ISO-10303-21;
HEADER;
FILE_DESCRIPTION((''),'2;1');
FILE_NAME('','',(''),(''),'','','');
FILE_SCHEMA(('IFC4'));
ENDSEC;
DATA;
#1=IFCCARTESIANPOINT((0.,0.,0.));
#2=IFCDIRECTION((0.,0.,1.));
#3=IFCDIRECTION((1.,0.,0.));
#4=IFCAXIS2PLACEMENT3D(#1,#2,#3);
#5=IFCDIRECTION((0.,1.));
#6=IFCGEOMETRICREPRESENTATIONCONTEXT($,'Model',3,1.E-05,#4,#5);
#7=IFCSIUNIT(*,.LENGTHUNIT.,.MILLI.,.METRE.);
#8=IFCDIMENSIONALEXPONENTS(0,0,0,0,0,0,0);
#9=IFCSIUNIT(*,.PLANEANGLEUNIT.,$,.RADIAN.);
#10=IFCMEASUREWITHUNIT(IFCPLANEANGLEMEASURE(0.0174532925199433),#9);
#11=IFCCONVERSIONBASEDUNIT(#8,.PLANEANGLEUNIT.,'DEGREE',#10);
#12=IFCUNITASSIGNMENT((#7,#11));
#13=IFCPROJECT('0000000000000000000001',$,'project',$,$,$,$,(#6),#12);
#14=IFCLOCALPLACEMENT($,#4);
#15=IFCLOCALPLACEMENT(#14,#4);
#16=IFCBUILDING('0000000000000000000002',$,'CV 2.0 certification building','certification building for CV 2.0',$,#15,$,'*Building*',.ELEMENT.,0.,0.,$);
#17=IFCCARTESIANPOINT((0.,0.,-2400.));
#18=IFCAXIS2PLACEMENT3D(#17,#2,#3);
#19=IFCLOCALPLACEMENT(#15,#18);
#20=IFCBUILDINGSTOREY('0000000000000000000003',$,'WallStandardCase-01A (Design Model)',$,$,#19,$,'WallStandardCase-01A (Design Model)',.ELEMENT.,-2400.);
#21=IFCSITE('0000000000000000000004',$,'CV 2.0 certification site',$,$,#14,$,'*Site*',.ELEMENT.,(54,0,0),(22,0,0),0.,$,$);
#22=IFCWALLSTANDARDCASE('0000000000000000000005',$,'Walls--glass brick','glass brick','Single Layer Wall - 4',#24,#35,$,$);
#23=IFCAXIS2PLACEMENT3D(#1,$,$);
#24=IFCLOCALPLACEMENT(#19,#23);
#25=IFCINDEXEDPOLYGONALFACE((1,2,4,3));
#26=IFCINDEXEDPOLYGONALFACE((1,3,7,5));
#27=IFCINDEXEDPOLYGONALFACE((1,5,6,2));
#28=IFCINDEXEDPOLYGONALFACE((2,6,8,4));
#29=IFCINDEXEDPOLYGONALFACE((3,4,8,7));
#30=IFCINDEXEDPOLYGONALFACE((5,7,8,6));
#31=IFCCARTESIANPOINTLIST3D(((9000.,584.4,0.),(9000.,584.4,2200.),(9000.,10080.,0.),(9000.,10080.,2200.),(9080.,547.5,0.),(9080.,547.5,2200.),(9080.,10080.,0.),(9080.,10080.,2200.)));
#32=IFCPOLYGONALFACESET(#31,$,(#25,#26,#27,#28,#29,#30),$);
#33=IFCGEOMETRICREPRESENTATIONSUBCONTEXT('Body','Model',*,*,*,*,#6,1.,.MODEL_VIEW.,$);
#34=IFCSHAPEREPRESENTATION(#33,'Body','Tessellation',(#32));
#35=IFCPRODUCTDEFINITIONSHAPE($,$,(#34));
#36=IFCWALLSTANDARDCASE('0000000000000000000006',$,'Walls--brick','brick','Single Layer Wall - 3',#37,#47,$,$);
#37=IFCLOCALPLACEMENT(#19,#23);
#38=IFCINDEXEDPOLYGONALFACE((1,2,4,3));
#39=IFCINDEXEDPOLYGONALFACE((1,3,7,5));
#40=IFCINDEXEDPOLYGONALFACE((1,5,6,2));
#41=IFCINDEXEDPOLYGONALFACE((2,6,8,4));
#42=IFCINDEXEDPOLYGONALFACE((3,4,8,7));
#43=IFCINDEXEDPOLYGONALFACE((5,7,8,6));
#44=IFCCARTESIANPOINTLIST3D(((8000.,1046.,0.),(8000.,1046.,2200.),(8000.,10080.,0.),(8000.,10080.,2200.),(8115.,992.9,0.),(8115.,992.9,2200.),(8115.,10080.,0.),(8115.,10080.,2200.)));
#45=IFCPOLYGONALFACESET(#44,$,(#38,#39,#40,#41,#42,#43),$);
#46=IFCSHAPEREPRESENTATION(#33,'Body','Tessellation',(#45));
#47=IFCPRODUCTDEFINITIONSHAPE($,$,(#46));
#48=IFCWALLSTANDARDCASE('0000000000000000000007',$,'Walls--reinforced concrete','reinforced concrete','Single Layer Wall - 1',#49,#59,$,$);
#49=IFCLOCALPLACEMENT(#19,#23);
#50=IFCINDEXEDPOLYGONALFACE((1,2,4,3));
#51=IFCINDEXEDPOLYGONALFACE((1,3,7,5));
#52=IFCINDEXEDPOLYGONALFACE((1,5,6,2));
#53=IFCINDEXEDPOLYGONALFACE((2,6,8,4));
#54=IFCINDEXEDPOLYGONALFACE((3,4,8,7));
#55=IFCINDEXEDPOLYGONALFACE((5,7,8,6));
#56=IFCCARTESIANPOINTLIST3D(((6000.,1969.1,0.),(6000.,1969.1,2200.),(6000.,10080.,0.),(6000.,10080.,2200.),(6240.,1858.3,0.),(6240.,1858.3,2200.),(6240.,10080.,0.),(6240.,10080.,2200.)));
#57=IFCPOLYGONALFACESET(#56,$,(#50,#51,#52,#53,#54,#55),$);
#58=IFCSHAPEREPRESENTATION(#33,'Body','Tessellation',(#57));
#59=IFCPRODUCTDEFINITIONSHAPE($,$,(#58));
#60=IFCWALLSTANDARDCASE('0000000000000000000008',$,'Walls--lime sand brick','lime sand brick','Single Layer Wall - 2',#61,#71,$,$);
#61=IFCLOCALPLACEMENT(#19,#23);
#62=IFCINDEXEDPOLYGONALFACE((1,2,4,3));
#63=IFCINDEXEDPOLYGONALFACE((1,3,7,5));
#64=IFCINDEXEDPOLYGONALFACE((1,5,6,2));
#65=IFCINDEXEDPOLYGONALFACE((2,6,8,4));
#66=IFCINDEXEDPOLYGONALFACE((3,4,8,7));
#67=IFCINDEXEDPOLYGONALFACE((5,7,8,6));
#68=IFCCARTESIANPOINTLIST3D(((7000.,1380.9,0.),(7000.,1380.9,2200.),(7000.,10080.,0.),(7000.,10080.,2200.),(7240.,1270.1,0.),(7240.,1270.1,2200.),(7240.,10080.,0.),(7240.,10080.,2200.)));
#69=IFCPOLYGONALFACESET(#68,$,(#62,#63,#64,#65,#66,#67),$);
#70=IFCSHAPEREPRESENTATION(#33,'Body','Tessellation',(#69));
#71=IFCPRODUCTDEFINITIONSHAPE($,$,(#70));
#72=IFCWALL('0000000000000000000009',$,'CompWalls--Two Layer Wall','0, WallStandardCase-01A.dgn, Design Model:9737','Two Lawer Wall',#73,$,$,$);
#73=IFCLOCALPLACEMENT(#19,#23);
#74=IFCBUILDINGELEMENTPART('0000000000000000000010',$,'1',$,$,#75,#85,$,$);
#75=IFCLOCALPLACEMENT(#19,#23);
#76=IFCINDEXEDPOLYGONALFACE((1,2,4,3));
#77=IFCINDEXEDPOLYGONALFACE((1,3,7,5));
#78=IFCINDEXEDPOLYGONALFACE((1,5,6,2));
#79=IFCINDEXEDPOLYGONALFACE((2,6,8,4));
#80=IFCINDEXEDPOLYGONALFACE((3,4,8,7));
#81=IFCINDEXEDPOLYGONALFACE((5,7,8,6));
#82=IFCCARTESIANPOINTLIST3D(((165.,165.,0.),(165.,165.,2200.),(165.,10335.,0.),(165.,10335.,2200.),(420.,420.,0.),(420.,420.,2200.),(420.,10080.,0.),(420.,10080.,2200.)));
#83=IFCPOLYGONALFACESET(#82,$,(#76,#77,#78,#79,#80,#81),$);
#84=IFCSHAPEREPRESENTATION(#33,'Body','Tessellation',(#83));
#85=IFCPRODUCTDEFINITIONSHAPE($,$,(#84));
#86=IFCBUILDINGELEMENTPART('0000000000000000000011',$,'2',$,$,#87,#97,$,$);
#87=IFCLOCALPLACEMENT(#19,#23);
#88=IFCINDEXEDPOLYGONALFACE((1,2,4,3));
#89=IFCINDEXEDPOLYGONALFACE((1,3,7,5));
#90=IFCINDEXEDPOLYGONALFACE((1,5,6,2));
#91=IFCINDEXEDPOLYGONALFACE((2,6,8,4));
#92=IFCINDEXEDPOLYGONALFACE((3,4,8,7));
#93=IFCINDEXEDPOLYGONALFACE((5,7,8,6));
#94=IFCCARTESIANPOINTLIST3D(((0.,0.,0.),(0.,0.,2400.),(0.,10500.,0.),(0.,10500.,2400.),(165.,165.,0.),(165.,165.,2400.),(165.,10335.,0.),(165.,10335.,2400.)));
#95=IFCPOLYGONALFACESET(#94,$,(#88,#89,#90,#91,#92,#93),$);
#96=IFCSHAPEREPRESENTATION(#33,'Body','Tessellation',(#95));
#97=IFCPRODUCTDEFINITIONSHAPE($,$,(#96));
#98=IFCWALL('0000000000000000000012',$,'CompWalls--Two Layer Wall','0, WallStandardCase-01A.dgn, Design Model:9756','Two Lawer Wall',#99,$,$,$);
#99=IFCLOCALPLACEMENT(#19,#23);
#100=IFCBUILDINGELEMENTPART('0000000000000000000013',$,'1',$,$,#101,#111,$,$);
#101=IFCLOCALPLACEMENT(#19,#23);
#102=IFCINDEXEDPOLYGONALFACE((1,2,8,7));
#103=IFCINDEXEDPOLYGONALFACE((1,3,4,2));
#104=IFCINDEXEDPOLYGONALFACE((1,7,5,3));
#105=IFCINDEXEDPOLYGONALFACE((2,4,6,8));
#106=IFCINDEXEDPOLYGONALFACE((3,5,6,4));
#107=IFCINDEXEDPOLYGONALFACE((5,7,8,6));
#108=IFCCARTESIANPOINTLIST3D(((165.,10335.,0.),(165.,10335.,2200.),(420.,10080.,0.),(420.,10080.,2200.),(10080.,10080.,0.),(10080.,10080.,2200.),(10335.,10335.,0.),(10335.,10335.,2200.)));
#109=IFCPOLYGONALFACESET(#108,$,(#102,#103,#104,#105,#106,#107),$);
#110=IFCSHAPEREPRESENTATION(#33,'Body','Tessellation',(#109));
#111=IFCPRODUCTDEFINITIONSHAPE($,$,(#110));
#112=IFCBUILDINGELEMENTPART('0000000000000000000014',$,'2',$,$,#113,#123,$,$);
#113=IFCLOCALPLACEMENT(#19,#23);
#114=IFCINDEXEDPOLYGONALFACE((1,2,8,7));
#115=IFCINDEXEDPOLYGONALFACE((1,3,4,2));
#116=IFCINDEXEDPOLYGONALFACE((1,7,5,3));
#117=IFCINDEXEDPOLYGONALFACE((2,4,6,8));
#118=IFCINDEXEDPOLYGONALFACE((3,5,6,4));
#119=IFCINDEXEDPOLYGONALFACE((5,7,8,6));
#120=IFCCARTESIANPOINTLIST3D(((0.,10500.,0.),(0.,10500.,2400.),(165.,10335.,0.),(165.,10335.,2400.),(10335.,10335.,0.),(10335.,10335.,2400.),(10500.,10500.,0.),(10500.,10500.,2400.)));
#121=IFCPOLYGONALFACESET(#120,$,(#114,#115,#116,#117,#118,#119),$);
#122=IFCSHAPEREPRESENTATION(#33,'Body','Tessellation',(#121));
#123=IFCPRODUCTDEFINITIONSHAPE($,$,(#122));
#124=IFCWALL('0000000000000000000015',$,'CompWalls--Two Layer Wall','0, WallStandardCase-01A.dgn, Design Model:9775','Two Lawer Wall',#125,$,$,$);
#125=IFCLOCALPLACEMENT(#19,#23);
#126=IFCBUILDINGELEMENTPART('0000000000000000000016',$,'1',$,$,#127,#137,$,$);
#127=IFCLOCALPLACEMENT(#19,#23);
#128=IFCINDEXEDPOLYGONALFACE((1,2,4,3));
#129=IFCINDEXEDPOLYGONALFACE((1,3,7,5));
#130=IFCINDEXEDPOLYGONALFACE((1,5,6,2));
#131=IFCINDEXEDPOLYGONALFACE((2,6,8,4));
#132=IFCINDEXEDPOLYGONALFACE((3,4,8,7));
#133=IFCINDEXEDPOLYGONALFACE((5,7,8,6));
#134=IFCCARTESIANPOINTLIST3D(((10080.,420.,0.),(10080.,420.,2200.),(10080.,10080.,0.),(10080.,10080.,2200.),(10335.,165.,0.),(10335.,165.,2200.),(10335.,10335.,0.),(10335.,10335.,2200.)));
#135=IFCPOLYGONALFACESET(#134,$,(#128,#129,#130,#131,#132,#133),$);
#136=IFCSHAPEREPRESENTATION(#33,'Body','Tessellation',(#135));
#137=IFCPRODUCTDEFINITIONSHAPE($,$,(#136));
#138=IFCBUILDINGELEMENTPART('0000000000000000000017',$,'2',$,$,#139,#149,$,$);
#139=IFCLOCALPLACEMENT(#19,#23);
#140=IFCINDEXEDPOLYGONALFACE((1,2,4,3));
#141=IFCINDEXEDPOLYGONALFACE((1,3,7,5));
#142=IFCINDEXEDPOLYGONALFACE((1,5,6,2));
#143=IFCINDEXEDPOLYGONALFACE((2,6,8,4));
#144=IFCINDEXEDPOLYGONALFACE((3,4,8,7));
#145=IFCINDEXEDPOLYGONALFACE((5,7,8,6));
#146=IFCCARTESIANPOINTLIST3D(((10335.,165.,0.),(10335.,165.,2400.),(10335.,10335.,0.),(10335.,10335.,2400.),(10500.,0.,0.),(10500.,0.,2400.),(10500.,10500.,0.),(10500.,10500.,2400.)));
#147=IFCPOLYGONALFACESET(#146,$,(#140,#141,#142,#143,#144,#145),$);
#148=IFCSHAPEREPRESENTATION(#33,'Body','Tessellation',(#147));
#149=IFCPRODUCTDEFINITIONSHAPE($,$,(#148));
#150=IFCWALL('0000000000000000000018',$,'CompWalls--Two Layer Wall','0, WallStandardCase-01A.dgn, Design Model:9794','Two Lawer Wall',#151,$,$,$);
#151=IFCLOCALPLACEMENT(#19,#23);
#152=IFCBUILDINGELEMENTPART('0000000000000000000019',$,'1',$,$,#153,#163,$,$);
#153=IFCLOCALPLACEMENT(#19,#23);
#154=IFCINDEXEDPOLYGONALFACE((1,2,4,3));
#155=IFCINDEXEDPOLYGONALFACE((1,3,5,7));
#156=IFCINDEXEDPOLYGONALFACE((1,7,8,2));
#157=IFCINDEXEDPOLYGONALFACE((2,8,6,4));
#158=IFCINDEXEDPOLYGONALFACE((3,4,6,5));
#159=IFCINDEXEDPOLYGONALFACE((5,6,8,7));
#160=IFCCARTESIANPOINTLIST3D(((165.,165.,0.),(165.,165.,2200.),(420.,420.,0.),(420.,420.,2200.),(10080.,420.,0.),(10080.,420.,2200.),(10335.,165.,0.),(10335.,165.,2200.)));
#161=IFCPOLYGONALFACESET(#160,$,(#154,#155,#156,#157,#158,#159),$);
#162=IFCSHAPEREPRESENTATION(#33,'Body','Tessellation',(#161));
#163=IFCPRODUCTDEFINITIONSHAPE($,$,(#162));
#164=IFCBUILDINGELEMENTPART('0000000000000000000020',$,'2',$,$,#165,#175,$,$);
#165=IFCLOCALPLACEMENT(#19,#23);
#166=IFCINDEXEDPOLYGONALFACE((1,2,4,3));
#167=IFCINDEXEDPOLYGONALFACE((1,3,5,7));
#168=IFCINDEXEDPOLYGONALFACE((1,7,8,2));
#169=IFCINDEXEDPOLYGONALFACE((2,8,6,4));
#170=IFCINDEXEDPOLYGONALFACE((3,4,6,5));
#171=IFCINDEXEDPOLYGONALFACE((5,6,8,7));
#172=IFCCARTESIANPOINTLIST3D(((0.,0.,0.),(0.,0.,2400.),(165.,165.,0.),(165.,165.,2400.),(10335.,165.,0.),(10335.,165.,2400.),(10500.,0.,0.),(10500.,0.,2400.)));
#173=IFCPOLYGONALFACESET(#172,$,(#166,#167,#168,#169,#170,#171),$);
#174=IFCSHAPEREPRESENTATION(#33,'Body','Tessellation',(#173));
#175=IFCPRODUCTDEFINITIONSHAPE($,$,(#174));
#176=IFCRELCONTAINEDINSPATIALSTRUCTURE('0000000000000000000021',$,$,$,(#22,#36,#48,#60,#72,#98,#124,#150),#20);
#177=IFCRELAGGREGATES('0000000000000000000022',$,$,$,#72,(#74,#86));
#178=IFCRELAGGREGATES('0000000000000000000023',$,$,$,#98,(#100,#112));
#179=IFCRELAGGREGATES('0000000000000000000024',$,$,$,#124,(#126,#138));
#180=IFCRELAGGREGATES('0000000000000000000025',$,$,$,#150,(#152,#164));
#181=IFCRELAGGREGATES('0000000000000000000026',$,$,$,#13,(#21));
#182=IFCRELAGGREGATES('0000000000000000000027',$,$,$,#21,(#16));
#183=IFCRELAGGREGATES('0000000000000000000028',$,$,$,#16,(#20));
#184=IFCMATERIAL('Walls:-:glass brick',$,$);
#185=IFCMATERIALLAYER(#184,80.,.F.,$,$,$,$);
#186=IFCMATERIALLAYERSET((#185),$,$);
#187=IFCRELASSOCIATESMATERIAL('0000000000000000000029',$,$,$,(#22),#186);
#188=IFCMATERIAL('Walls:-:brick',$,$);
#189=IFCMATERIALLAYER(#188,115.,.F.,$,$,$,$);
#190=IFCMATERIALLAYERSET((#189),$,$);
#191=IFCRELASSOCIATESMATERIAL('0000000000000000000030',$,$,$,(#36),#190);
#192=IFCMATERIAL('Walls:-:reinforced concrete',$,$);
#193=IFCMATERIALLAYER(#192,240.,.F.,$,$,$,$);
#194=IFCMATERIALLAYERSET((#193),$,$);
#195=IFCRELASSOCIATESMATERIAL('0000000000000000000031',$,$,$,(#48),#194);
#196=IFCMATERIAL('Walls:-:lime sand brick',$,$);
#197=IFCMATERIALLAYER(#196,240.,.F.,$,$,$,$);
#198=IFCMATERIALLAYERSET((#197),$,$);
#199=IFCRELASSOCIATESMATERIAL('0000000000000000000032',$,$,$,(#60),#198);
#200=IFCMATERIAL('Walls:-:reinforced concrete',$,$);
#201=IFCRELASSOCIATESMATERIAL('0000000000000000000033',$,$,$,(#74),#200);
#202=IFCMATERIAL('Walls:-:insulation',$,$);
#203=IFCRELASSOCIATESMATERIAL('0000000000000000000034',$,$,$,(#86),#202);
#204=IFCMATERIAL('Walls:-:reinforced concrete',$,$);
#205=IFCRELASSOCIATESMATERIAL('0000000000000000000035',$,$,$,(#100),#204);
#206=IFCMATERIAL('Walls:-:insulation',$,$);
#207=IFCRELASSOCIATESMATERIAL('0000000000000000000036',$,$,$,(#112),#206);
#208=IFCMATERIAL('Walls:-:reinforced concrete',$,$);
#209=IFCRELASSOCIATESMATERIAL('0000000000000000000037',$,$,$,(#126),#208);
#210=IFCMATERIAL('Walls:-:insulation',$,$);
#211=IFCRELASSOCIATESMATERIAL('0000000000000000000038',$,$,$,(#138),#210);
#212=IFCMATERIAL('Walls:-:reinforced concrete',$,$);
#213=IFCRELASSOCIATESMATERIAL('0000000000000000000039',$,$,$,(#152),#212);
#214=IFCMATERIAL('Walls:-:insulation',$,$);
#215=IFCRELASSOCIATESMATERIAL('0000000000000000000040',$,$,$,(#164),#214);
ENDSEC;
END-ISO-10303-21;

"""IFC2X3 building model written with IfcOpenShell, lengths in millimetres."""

from ifc_helpers import new_model, entity, si_unit, converted_unit, direction, frame, origin_with_axes, place, context, subcontext, project, spatial, polyline, outline, extrude, material, layer, layer_set, layer_usage, element, aggregate, save


model = new_model("IFC2X3")

# Units and contexts
model_context = context("Model", 3, precision=1e-05, world=origin_with_axes(), true_north=direction((0.0, 1.0)))
body_context = subcontext(model_context, "Body", "Model", "MODEL_VIEW", scale=1.0)
ifc_project = project(units=[si_unit("LENGTHUNIT", "METRE", prefix="MILLI"), converted_unit("PLANEANGLEUNIT", "DEGREE", entity("IfcPlaneAngleMeasure", 0.0174532925199433), si_unit("PLANEANGLEUNIT", "RADIAN"), dimensions=[0, 0, 0, 0, 0, 0, 0])], contexts=[model_context])

# Site, building, storey
site_placement = place(None, origin_with_axes())
site = spatial("IfcSite", under=ifc_project, at=site_placement, Name="CV 2.0 certification site", LongName="*Site*", CompositionType="ELEMENT", RefLatitude=(54, 0, 0), RefLongitude=(22, 0, 0), RefElevation=0.0)
building_placement = place(site_placement, origin_with_axes())
building = spatial("IfcBuilding", under=site, at=building_placement, Name="CV 2.0 certification building", Description="certification building for CV 2.0", LongName="*Building*", CompositionType="ELEMENT", ElevationOfRefHeight=0.0, ElevationOfTerrain=0.0)
storey_placement = place(building_placement, frame((0.0, 0.0, -2400.0), z_axis=(0.0, 0.0, 1.0), x_axis=(1.0, 0.0, 0.0)))
storey = spatial("IfcBuildingStorey", under=building, at=storey_placement, Name="WallStandardCase-01A (Design Model)", LongName="WallStandardCase-01A (Design Model)", CompositionType="ELEMENT", Elevation=-2400.0)

# Walls
ifc_material_1 = material(Name="Walls:-:glass brick")
ifc_layer_1 = layer(ifc_material_1, 80.0, ventilated=False)
ifc_layer_set_1 = layer_set([ifc_layer_1])
ifc_layer_usage_1 = layer_usage(ifc_layer_set_1, "AXIS2", "POSITIVE", 0.0)
wall_1_placement = place(storey_placement, frame((9000.0, 584.4, 0.0), z_axis=(0.0, 0.0, 1.0), x_axis=(0.0, 1.0, 0.0)))
element("IfcWallStandardCase", 1, at=wall_1_placement, inside=storey, material=ifc_layer_usage_1, Name="Walls--glass brick", Description="glass brick", ObjectType="Single Layer Wall - 4", context=body_context, shape_type="SweptSolid", body=[
    extrude(outline(polyline([(9495.6, 0.0), (0.0, 0.0), (-36.9, -80.0), (9495.6, -80.0), (9495.6, 0.0)])), origin_with_axes(), (0.0, 0.0, 1.0), 2200.0),
])
ifc_material_2 = material(Name="Walls:-:brick")
ifc_layer_2 = layer(ifc_material_2, 115.0, ventilated=False)
ifc_layer_set_2 = layer_set([ifc_layer_2])
ifc_layer_usage_2 = layer_usage(ifc_layer_set_2, "AXIS2", "POSITIVE", 0.0)
wall_2_placement = place(storey_placement, frame((8000.0, 1046.0, 0.0), z_axis=(0.0, 0.0, 1.0), x_axis=(0.0, 1.0, 0.0)))
element("IfcWallStandardCase", 2, at=wall_2_placement, inside=storey, material=ifc_layer_usage_2, Name="Walls--brick", Description="brick", ObjectType="Single Layer Wall - 3", context=body_context, shape_type="SweptSolid", body=[
    extrude(outline(polyline([(9034.0, 0.0), (0.0, 0.0), (-53.1, -115.0), (9034.0, -115.0), (9034.0, 0.0)])), origin_with_axes(), (0.0, 0.0, 1.0), 2200.0),
])
ifc_material_3 = material(Name="Walls:-:reinforced concrete")
ifc_layer_3 = layer(ifc_material_3, 240.0, ventilated=False)
ifc_layer_set_3 = layer_set([ifc_layer_3])
ifc_layer_usage_3 = layer_usage(ifc_layer_set_3, "AXIS2", "POSITIVE", 0.0)
wall_3_placement = place(storey_placement, frame((6000.0, 1969.1, 0.0), z_axis=(0.0, 0.0, 1.0), x_axis=(0.0, 1.0, 0.0)))
element("IfcWallStandardCase", 3, at=wall_3_placement, inside=storey, material=ifc_layer_usage_3, Name="Walls--reinforced concrete", Description="reinforced concrete", ObjectType="Single Layer Wall - 1", context=body_context, shape_type="SweptSolid", body=[
    extrude(outline(polyline([(8110.9, 0.0), (0.0, 0.0), (-110.8, -240.0), (8110.9, -240.0), (8110.9, 0.0)])), origin_with_axes(), (0.0, 0.0, 1.0), 2200.0),
])
ifc_material_4 = material(Name="Walls:-:lime sand brick")
ifc_layer_4 = layer(ifc_material_4, 240.0, ventilated=False)
ifc_layer_set_4 = layer_set([ifc_layer_4])
ifc_layer_usage_4 = layer_usage(ifc_layer_set_4, "AXIS2", "POSITIVE", 0.0)
wall_4_placement = place(storey_placement, frame((7000.0, 1380.9, 0.0), z_axis=(0.0, 0.0, 1.0), x_axis=(0.0, 1.0, 0.0)))
element("IfcWallStandardCase", 4, at=wall_4_placement, inside=storey, material=ifc_layer_usage_4, Name="Walls--lime sand brick", Description="lime sand brick", ObjectType="Single Layer Wall - 2", context=body_context, shape_type="SweptSolid", body=[
    extrude(outline(polyline([(8699.1, 0.0), (0.0, 0.0), (-110.8, -240.0), (8699.1, -240.0), (8699.1, 0.0)])), origin_with_axes(), (0.0, 0.0, 1.0), 2200.0),
])

# Walls, building element parts
wall_5_placement = place(storey_placement, frame((165.0, 165.0, 0.0), z_axis=(0.0, 0.0, 1.0), x_axis=(0.0, 1.0, 0.0)))
wall_5 = element("IfcWall", 5, at=wall_5_placement, inside=storey, Name="CompWalls--Two Layer Wall", Description="0, WallStandardCase-01A.dgn, Design Model:9737", ObjectType="Two Lawer Wall")
ifc_material_5 = material(Name="Walls:-:reinforced concrete")
building_element_part_1_placement = place(wall_5_placement, origin_with_axes())
building_element_part_1 = element("IfcBuildingElementPart", 6, at=building_element_part_1_placement, material=ifc_material_5, Name="1", context=body_context, shape_type="SweptSolid", body=[
    extrude(outline(polyline([(10170.0, 0.0), (0.0, 0.0), (255.0, -255.0), (9915.0, -255.0), (10170.0, 0.0)])), origin_with_axes(), (0.0, 0.0, 1.0), 2200.0),
])
ifc_material_6 = material(Name="Walls:-:insulation")
building_element_part_2_placement = place(wall_5_placement, origin_with_axes())
building_element_part_2 = element("IfcBuildingElementPart", 7, at=building_element_part_2_placement, material=ifc_material_6, Name="2", context=body_context, shape_type="SweptSolid", body=[
    extrude(outline(polyline([(10335.0, 165.0), (-165.0, 165.0), (0.0, 0.0), (10170.0, 0.0), (10335.0, 165.0)])), origin_with_axes(), (0.0, 0.0, 1.0), 2400.0),
])
aggregate(wall_5, [building_element_part_1, building_element_part_2])
wall_6_placement = place(storey_placement, frame((165.0, 10335.0, 0.0), z_axis=(0.0, 0.0, 1.0), x_axis=(1.0, 0.0, 0.0)))
wall_6 = element("IfcWall", 8, at=wall_6_placement, inside=storey, Name="CompWalls--Two Layer Wall", Description="0, WallStandardCase-01A.dgn, Design Model:9756", ObjectType="Two Lawer Wall")
ifc_material_7 = material(Name="Walls:-:reinforced concrete")
building_element_part_3_placement = place(wall_6_placement, origin_with_axes())
building_element_part_3 = element("IfcBuildingElementPart", 9, at=building_element_part_3_placement, material=ifc_material_7, Name="1", context=body_context, shape_type="SweptSolid", body=[
    extrude(outline(polyline([(10170.0, 0.0), (0.0, 0.0), (255.0, -255.0), (9915.0, -255.0), (10170.0, 0.0)])), origin_with_axes(), (0.0, 0.0, 1.0), 2200.0),
])
ifc_material_8 = material(Name="Walls:-:insulation")
building_element_part_4_placement = place(wall_6_placement, origin_with_axes())
building_element_part_4 = element("IfcBuildingElementPart", 10, at=building_element_part_4_placement, material=ifc_material_8, Name="2", context=body_context, shape_type="SweptSolid", body=[
    extrude(outline(polyline([(10335.0, 165.0), (-165.0, 165.0), (0.0, 0.0), (10170.0, 0.0), (10335.0, 165.0)])), origin_with_axes(), (0.0, 0.0, 1.0), 2400.0),
])
aggregate(wall_6, [building_element_part_3, building_element_part_4])
wall_7_placement = place(storey_placement, frame((10335.0, 10335.0, 0.0), z_axis=(0.0, 0.0, 1.0), x_axis=(0.0, -1.0, 0.0)))
wall_7 = element("IfcWall", 11, at=wall_7_placement, inside=storey, Name="CompWalls--Two Layer Wall", Description="0, WallStandardCase-01A.dgn, Design Model:9775", ObjectType="Two Lawer Wall")
ifc_material_9 = material(Name="Walls:-:reinforced concrete")
building_element_part_5_placement = place(wall_7_placement, origin_with_axes())
building_element_part_5 = element("IfcBuildingElementPart", 12, at=building_element_part_5_placement, material=ifc_material_9, Name="1", context=body_context, shape_type="SweptSolid", body=[
    extrude(outline(polyline([(10170.0, 0.0), (0.0, 0.0), (255.0, -255.0), (9915.0, -255.0), (10170.0, 0.0)])), origin_with_axes(), (0.0, 0.0, 1.0), 2200.0),
])
ifc_material_10 = material(Name="Walls:-:insulation")
building_element_part_6_placement = place(wall_7_placement, origin_with_axes())
building_element_part_6 = element("IfcBuildingElementPart", 13, at=building_element_part_6_placement, material=ifc_material_10, Name="2", context=body_context, shape_type="SweptSolid", body=[
    extrude(outline(polyline([(10335.0, 165.0), (-165.0, 165.0), (0.0, 0.0), (10170.0, 0.0), (10335.0, 165.0)])), origin_with_axes(), (0.0, 0.0, 1.0), 2400.0),
])
aggregate(wall_7, [building_element_part_5, building_element_part_6])
wall_8_placement = place(storey_placement, frame((10335.0, 165.0, 0.0), z_axis=(0.0, 0.0, 1.0), x_axis=(-1.0, 0.0, 0.0)))
wall_8 = element("IfcWall", 14, at=wall_8_placement, inside=storey, Name="CompWalls--Two Layer Wall", Description="0, WallStandardCase-01A.dgn, Design Model:9794", ObjectType="Two Lawer Wall")
ifc_material_11 = material(Name="Walls:-:reinforced concrete")
building_element_part_7_placement = place(wall_8_placement, origin_with_axes())
building_element_part_7 = element("IfcBuildingElementPart", 15, at=building_element_part_7_placement, material=ifc_material_11, Name="1", context=body_context, shape_type="SweptSolid", body=[
    extrude(outline(polyline([(10170.0, 0.0), (0.0, 0.0), (255.0, -255.0), (9915.0, -255.0), (10170.0, 0.0)])), origin_with_axes(), (0.0, 0.0, 1.0), 2200.0),
])
ifc_material_12 = material(Name="Walls:-:insulation")
building_element_part_8_placement = place(wall_8_placement, origin_with_axes())
building_element_part_8 = element("IfcBuildingElementPart", 16, at=building_element_part_8_placement, material=ifc_material_12, Name="2", context=body_context, shape_type="SweptSolid", body=[
    extrude(outline(polyline([(10335.0, 165.0), (-165.0, 165.0), (0.0, 0.0), (10170.0, 0.0), (10335.0, 165.0)])), origin_with_axes(), (0.0, 0.0, 1.0), 2400.0),
])
aggregate(wall_8, [building_element_part_7, building_element_part_8])

save(model, "model.ifc")
